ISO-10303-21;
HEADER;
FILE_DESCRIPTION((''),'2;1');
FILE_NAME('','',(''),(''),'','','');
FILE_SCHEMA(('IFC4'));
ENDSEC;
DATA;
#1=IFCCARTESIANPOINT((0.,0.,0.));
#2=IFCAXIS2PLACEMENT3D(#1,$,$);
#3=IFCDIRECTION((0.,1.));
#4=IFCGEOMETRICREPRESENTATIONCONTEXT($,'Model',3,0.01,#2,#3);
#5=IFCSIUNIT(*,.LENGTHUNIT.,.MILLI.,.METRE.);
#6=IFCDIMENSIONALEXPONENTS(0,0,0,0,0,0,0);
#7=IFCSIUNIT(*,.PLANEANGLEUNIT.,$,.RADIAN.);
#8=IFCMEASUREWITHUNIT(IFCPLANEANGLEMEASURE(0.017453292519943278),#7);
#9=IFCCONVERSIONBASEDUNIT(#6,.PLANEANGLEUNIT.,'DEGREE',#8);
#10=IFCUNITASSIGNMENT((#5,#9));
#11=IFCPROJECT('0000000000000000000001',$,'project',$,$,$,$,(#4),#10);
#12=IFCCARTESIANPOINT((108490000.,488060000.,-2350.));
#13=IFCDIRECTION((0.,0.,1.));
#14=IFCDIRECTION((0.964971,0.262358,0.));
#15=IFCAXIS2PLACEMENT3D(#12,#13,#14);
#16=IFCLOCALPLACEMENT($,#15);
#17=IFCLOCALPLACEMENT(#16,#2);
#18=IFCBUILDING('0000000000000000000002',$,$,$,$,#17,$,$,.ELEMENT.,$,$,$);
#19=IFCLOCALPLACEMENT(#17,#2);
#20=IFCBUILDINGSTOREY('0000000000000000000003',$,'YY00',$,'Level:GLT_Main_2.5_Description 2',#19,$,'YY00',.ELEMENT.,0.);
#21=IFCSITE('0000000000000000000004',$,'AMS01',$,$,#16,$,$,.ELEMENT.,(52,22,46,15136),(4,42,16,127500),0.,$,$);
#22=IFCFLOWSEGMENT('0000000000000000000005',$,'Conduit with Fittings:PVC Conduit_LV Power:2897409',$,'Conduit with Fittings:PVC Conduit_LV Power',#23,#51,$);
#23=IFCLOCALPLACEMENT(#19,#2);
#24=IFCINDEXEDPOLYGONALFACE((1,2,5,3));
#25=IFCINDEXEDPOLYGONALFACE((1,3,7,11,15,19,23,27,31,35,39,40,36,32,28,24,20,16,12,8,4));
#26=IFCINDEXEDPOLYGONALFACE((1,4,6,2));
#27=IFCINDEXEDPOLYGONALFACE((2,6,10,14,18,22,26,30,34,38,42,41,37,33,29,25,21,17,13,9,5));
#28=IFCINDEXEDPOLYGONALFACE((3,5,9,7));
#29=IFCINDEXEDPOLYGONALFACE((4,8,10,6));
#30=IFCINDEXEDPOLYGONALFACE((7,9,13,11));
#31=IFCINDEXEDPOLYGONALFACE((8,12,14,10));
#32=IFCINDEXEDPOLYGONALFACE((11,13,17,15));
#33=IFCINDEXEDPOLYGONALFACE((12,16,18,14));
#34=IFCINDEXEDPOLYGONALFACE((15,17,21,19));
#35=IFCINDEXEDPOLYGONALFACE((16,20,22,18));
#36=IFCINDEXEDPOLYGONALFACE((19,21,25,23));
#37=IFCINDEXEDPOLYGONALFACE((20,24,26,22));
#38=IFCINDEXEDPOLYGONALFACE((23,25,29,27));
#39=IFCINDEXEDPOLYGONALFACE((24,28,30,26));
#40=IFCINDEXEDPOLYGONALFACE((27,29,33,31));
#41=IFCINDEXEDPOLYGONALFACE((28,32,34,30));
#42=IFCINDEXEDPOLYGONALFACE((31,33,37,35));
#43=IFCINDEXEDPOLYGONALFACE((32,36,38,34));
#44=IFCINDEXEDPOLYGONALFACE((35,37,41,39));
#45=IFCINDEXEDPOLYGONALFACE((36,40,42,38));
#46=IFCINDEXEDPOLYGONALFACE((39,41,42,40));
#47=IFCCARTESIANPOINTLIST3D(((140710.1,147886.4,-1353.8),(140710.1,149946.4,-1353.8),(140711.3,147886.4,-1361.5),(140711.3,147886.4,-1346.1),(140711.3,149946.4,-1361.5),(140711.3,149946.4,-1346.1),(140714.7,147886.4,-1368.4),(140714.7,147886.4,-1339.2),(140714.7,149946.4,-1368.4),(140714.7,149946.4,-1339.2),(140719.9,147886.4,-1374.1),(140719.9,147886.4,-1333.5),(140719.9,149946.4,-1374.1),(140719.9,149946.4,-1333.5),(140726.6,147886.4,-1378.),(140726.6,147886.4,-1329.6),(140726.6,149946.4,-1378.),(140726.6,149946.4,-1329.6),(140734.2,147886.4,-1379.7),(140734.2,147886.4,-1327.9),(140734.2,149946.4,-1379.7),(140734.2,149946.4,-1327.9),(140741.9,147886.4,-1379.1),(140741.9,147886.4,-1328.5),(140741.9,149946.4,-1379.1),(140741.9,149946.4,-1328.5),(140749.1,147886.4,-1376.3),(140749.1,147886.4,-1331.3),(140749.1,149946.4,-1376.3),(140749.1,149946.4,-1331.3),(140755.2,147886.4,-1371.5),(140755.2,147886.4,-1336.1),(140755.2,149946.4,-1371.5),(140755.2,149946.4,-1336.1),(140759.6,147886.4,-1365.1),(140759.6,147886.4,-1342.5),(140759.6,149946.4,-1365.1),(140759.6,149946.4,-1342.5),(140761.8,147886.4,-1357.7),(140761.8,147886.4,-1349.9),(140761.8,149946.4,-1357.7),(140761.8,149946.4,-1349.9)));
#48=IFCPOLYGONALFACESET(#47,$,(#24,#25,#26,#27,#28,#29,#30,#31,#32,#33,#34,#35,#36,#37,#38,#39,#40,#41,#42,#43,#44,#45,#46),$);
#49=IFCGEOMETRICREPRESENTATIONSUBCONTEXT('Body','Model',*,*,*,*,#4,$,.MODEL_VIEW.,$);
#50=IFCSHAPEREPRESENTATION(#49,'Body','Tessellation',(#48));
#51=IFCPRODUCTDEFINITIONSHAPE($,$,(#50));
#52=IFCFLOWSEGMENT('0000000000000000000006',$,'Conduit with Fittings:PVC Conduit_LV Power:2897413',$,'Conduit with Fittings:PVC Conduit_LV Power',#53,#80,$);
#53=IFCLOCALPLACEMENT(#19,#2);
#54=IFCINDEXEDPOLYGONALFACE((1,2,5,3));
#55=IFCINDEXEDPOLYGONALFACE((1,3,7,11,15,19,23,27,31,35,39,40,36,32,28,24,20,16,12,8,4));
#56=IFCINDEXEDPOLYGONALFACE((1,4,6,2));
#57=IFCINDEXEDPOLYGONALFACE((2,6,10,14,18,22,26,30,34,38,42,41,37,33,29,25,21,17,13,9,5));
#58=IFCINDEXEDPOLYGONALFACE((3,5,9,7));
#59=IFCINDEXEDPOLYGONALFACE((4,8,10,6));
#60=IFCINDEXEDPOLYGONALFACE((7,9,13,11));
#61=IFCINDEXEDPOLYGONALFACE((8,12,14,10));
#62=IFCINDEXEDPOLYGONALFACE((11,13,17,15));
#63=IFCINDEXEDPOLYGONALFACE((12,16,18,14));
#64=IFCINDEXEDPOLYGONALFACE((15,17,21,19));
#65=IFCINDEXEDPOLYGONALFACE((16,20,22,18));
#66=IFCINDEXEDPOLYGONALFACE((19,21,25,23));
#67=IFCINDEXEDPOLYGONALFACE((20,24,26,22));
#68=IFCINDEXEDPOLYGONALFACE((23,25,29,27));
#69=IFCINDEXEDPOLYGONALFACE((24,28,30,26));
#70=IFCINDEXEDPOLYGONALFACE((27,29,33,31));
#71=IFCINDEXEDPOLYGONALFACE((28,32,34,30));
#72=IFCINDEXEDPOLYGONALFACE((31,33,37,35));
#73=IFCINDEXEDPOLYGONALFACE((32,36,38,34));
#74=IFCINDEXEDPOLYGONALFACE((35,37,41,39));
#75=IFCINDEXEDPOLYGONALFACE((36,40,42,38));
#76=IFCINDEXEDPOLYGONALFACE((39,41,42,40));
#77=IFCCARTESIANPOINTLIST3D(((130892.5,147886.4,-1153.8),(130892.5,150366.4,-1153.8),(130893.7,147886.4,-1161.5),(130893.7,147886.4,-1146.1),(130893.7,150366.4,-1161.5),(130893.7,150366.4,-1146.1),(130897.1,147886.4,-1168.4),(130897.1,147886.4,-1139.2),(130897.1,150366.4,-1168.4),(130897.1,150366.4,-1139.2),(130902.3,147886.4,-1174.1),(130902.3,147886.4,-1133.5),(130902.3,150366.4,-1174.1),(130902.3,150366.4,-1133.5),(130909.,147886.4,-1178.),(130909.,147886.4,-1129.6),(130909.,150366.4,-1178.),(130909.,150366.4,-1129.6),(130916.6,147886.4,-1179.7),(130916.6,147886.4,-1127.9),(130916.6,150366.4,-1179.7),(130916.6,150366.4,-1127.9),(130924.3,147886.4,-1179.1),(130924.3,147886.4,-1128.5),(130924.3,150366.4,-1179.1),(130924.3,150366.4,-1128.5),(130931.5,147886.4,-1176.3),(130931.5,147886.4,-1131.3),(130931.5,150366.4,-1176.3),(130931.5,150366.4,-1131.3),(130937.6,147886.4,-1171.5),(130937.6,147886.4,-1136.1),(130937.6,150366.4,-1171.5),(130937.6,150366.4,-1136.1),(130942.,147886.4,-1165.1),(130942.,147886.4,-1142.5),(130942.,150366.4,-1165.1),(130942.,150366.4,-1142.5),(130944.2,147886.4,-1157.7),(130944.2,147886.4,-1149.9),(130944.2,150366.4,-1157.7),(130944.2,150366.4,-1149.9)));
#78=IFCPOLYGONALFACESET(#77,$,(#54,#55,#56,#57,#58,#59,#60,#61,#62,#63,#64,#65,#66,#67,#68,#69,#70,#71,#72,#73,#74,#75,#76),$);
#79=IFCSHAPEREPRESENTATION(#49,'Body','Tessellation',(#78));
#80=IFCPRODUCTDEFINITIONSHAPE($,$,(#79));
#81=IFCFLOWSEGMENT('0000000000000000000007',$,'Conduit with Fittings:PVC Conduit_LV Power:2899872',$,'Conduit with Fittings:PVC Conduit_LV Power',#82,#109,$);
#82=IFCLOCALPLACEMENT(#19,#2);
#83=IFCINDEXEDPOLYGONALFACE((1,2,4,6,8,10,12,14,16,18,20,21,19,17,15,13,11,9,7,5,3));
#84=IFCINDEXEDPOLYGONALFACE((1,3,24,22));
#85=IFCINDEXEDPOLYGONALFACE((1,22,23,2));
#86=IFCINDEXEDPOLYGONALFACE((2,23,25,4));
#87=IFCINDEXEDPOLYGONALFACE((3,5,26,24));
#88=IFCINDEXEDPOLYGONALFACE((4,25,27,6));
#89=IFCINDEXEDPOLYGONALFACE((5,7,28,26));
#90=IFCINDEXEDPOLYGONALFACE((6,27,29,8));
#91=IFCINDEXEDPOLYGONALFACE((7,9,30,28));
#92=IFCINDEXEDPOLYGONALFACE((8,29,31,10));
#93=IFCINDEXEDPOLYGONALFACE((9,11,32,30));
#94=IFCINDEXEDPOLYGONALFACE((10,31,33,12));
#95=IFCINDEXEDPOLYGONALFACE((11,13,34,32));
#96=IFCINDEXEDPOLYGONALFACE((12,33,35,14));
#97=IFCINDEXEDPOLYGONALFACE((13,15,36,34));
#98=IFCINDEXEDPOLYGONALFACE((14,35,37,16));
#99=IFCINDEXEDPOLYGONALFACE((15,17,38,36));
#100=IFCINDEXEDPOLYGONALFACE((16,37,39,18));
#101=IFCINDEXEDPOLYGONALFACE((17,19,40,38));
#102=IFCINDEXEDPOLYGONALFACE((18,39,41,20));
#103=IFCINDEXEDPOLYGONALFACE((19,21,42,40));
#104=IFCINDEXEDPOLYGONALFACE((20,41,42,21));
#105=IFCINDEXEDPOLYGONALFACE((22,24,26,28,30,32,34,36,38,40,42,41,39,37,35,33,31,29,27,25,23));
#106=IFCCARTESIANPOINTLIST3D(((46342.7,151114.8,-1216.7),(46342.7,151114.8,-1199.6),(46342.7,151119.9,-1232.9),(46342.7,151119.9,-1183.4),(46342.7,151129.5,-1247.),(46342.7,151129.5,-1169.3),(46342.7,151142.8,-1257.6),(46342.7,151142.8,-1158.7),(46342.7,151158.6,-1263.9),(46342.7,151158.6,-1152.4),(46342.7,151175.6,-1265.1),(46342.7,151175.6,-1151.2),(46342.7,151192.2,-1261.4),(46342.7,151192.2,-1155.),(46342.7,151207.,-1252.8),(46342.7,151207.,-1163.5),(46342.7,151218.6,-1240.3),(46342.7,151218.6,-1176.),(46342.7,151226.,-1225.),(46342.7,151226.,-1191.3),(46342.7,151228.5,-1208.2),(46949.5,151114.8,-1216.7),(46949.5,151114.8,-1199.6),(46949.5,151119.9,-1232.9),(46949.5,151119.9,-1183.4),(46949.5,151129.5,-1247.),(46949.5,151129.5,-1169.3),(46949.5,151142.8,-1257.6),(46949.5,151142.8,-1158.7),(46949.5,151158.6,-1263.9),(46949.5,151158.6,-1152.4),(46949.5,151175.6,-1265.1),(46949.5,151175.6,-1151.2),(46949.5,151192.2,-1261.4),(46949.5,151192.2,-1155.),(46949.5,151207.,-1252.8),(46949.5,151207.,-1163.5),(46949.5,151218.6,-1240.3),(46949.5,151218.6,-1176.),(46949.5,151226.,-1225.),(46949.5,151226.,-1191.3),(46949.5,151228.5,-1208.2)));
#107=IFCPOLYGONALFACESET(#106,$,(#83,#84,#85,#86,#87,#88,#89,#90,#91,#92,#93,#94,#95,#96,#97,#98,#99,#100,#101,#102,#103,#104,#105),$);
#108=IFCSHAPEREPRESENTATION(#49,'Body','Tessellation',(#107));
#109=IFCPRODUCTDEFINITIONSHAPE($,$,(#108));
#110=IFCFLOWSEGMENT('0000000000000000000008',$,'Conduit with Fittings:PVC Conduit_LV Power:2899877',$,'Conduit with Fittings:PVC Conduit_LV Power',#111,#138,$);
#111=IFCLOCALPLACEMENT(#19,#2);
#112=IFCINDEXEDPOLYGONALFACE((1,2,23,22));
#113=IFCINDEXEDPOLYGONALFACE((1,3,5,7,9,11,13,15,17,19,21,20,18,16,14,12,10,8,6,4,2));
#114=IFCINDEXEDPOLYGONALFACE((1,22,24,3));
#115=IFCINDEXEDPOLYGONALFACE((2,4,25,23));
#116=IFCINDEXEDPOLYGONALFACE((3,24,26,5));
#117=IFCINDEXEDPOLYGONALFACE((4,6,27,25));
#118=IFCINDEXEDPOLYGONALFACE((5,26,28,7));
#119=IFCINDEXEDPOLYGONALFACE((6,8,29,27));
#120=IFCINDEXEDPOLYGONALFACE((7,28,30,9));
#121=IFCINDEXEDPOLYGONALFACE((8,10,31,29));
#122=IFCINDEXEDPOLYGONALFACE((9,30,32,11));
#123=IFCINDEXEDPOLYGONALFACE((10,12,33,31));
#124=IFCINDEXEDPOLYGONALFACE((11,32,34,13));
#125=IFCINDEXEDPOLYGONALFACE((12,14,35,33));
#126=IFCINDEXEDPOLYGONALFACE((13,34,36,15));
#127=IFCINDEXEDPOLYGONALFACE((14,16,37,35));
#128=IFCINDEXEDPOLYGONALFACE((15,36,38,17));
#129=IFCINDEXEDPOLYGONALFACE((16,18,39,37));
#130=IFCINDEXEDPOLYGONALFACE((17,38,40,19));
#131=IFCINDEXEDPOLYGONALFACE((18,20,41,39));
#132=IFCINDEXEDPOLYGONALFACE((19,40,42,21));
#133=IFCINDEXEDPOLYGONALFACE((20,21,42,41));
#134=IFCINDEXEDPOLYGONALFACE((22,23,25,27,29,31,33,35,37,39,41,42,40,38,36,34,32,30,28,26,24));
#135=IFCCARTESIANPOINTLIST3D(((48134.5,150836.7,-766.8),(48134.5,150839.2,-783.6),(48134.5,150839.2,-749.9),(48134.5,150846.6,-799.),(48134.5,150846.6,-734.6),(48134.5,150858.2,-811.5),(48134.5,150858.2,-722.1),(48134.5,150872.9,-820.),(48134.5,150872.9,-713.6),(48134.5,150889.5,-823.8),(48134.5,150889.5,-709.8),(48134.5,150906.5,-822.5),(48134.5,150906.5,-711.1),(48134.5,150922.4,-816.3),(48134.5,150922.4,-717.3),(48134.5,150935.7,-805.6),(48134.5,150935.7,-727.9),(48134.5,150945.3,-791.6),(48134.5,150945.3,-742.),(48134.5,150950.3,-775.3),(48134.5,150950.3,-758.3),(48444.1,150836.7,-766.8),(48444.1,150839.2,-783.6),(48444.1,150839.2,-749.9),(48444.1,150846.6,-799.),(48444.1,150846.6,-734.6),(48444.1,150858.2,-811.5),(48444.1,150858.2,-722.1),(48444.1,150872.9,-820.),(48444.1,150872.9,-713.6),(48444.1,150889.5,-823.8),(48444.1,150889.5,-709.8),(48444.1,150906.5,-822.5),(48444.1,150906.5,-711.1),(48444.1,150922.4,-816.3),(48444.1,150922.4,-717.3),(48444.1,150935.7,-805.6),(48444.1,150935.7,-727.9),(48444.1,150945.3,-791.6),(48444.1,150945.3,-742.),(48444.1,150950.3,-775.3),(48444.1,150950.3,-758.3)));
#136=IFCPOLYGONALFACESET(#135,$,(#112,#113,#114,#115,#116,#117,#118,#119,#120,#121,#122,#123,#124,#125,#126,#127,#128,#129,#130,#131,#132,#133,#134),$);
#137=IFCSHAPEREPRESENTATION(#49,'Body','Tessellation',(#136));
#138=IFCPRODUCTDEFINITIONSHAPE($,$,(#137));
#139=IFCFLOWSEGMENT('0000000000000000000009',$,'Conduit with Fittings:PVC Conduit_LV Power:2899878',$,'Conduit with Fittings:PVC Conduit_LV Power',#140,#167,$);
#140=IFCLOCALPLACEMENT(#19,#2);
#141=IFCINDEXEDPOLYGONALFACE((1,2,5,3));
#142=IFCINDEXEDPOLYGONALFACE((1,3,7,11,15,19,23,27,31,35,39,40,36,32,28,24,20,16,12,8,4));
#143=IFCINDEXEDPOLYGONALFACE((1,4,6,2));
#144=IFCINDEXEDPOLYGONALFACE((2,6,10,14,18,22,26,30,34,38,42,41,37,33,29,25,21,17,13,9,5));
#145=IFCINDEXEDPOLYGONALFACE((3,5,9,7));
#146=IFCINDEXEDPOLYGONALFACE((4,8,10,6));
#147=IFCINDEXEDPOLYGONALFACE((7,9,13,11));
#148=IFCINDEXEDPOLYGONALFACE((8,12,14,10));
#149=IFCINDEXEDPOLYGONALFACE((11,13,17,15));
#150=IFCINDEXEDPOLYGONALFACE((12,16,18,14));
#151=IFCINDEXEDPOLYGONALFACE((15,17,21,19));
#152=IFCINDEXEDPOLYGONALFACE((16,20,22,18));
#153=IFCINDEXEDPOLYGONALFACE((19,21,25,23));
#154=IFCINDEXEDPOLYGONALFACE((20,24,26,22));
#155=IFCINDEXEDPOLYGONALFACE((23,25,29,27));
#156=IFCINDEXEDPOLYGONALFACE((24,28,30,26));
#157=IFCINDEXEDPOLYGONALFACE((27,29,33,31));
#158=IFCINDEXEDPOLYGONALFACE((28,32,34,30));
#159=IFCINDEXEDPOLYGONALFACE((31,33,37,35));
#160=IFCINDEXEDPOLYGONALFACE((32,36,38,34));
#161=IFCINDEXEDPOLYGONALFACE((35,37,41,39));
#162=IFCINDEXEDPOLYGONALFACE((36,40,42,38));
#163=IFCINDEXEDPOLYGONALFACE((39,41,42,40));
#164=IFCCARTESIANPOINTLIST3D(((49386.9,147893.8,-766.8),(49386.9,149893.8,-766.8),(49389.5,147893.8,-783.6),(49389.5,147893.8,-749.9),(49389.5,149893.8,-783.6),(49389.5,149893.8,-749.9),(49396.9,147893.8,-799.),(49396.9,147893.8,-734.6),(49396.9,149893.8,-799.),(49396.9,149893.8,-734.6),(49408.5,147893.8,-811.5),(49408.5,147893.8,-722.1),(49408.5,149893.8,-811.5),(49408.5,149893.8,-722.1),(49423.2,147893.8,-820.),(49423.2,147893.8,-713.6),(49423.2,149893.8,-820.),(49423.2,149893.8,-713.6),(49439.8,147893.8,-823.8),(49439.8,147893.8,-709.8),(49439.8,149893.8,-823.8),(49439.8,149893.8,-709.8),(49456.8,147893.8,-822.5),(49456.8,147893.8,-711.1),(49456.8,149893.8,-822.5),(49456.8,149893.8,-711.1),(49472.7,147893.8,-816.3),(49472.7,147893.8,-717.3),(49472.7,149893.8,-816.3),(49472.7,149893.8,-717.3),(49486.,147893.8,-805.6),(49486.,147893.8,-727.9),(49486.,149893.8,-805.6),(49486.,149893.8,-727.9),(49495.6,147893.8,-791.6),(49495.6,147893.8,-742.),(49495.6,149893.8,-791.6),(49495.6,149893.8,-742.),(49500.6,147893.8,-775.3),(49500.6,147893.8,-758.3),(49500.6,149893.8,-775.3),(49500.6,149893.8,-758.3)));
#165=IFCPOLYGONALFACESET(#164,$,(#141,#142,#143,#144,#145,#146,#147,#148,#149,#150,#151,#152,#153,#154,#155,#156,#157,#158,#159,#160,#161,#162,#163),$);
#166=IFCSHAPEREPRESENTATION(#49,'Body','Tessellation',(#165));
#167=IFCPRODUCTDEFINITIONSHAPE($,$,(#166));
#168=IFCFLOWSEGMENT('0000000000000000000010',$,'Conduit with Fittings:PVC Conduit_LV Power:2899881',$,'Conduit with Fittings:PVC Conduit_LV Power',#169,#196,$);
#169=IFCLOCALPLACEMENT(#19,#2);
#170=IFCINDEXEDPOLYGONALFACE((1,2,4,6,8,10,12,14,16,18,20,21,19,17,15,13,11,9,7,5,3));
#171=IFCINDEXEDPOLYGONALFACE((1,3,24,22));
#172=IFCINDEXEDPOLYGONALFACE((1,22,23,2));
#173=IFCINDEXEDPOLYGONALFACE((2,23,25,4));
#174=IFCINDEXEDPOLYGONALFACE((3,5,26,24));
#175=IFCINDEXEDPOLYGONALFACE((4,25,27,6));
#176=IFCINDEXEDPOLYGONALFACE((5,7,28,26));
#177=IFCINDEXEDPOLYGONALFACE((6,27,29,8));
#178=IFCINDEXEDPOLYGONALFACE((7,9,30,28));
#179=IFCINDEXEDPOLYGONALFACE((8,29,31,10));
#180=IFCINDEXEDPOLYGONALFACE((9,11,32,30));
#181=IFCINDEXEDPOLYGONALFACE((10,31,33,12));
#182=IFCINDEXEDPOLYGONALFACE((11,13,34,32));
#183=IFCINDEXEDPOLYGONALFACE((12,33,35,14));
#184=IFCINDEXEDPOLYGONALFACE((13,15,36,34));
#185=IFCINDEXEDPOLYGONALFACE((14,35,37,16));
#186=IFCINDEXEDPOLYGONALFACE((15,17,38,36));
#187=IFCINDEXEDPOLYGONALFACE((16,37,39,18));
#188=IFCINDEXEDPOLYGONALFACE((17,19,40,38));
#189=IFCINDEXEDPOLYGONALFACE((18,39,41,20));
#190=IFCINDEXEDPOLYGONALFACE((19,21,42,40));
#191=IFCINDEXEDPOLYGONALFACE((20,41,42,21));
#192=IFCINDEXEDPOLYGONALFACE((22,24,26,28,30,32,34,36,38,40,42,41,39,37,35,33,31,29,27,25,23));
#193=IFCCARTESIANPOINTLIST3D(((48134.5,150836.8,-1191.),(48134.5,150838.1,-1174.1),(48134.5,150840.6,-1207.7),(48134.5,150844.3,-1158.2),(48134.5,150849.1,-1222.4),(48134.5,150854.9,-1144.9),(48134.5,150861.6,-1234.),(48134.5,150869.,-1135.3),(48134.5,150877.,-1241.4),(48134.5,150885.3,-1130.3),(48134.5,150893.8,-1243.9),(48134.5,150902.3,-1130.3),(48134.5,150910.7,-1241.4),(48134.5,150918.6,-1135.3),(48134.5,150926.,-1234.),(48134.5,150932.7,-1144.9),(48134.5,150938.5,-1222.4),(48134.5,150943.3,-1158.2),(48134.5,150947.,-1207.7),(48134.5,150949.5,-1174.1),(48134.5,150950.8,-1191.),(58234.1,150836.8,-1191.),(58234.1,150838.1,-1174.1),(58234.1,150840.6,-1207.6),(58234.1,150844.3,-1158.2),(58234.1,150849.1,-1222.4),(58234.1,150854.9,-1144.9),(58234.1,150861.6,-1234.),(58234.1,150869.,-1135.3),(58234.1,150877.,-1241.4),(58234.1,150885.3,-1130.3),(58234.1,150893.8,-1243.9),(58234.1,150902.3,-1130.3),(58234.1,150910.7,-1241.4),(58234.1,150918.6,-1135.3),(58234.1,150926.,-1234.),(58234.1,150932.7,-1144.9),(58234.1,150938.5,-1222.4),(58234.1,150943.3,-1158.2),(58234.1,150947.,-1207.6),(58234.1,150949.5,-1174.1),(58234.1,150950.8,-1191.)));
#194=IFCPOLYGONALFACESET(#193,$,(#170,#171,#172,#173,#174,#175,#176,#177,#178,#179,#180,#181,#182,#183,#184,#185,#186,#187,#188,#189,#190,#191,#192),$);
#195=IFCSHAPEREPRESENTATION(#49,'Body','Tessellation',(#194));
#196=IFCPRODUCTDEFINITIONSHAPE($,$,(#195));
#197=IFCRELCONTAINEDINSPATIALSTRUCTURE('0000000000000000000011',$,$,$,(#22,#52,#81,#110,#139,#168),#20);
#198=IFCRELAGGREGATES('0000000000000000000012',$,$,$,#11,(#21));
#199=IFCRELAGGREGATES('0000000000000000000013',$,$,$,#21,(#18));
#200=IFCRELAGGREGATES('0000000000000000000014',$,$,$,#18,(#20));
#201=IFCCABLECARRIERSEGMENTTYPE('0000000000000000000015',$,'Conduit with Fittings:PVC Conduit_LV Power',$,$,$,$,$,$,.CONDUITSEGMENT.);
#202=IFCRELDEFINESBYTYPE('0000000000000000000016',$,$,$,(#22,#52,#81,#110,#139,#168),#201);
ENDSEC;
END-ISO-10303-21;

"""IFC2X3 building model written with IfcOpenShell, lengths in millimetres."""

from ifc_helpers import new_model, entity, si_unit, converted_unit, direction, frame, frame_2d, origin, origin_2d_with_axis, place, context, subcontext, project, spatial, circle, extrude, type_object, element, save


model = new_model("IFC2X3")

# Units and contexts
model_context = context("Model", 3, precision=0.01, world=origin(), true_north=direction((0.0, 1.0)))
body_context = subcontext(model_context, "Body", "Model", "MODEL_VIEW")
ifc_project = project(units=[si_unit("LENGTHUNIT", "METRE", prefix="MILLI"), converted_unit("PLANEANGLEUNIT", "DEGREE", entity("IfcPlaneAngleMeasure", 0.017453292519943278), si_unit("PLANEANGLEUNIT", "RADIAN"), dimensions=[0, 0, 0, 0, 0, 0, 0])], contexts=[model_context])

# Site, building, storey
site_placement = place(None, frame((108490000.0, 488060000.0, -2350.0), z_axis=(0.0, 0.0, 1.0), x_axis=(0.964971, 0.262358, 0.0)))
site = spatial("IfcSite", under=ifc_project, at=site_placement, Name="AMS01", CompositionType="ELEMENT", RefLatitude=(52, 22, 46, 15136), RefLongitude=(4, 42, 16, 127500), RefElevation=0.0)
building_placement = place(site_placement, origin())
building = spatial("IfcBuilding", under=site, at=building_placement, CompositionType="ELEMENT")
storey_placement = place(building_placement, origin())
storey = spatial("IfcBuildingStorey", under=building, at=storey_placement, Name="YY00", ObjectType="Level:GLT_Main_2.5_Description 2", LongName="YY00", CompositionType="ELEMENT", Elevation=0.0)

# Flow segments
cable_carrier_segment_type = type_object("IfcCableCarrierSegmentType", Name="Conduit with Fittings:PVC Conduit_LV Power", PredefinedType="CONDUITSEGMENT")
flow_segment_1_placement = place(storey_placement, origin())
element("IfcFlowSegment", 1, at=flow_segment_1_placement, inside=storey, type_object=cable_carrier_segment_type, Name="Conduit with Fittings:PVC Conduit_LV Power:2897409", ObjectType="Conduit with Fittings:PVC Conduit_LV Power", context=body_context, shape_type="SweptSolid", body=[
    extrude(circle(Radius=26.0, at=frame_2d((0.0, 0.0), x_axis=(1.0, 0.0))), frame((140736.1, 147886.4, -1353.8), z_axis=(0.0, 1.0, 0.0), x_axis=(-1.0, 0.0, 0.0)), (0.0, 0.0, 1.0), 2060.0),
])
flow_segment_2_placement = place(storey_placement, origin())
element("IfcFlowSegment", 2, at=flow_segment_2_placement, inside=storey, type_object=cable_carrier_segment_type, Name="Conduit with Fittings:PVC Conduit_LV Power:2897413", ObjectType="Conduit with Fittings:PVC Conduit_LV Power", context=body_context, shape_type="SweptSolid", body=[
    extrude(circle(Radius=26.0, at=frame_2d((0.0, 0.0), x_axis=(1.0, 0.0))), frame((130918.5, 147886.4, -1153.8), z_axis=(0.0, 1.0, 0.0), x_axis=(-1.0, 0.0, 0.0)), (0.0, 0.0, 1.0), 2480.0),
])
flow_segment_3_placement = place(storey_placement, origin())
element("IfcFlowSegment", 3, at=flow_segment_3_placement, inside=storey, type_object=cable_carrier_segment_type, Name="Conduit with Fittings:PVC Conduit_LV Power:2899872", ObjectType="Conduit with Fittings:PVC Conduit_LV Power", context=body_context, shape_type="SweptSolid", body=[
    extrude(circle(Radius=57.2, at=frame_2d((0.0, 0.0), x_axis=(1.0, 0.0))), frame((46342.7, 151171.4, -1208.2), z_axis=(1.0, 0.0, 0.0), x_axis=(0.0, 1.0, 0.0)), (0.0, 0.0, 1.0), 606.8),
])
flow_segment_4_placement = place(storey_placement, origin())
element("IfcFlowSegment", 4, at=flow_segment_4_placement, inside=storey, type_object=cable_carrier_segment_type, Name="Conduit with Fittings:PVC Conduit_LV Power:2899877", ObjectType="Conduit with Fittings:PVC Conduit_LV Power", context=body_context, shape_type="SweptSolid", body=[
    extrude(circle(Radius=57.2, at=origin_2d_with_axis()), frame((48134.5, 150893.8, -766.8), z_axis=(1.0, 0.0, 0.0), x_axis=(0.0, -1.0, 0.0)), (0.0, 0.0, 1.0), 309.6),
])
flow_segment_5_placement = place(storey_placement, origin())
element("IfcFlowSegment", 5, at=flow_segment_5_placement, inside=storey, type_object=cable_carrier_segment_type, Name="Conduit with Fittings:PVC Conduit_LV Power:2899878", ObjectType="Conduit with Fittings:PVC Conduit_LV Power", context=body_context, shape_type="SweptSolid", body=[
    extrude(circle(Radius=57.2, at=origin_2d_with_axis()), frame((49444.1, 147893.8, -766.8), z_axis=(0.0, 1.0, 0.0), x_axis=(-1.0, 0.0, 0.0)), (0.0, 0.0, 1.0), 2000.0),
])
flow_segment_6_placement = place(storey_placement, origin())
element("IfcFlowSegment", 6, at=flow_segment_6_placement, inside=storey, type_object=cable_carrier_segment_type, Name="Conduit with Fittings:PVC Conduit_LV Power:2899881", ObjectType="Conduit with Fittings:PVC Conduit_LV Power", context=body_context, shape_type="SweptSolid", body=[
    extrude(circle(Radius=57.1, at=frame_2d((0.0, 0.0), x_axis=(1.0, 0.0))), frame((48134.5, 150893.8, -1186.8), z_axis=(1.0, 0.0, 0.0), x_axis=(0.0, 0.0, -1.0)), (0.0, 0.0, 1.0), 10099.6),
])

save(model, "model.ifc")
